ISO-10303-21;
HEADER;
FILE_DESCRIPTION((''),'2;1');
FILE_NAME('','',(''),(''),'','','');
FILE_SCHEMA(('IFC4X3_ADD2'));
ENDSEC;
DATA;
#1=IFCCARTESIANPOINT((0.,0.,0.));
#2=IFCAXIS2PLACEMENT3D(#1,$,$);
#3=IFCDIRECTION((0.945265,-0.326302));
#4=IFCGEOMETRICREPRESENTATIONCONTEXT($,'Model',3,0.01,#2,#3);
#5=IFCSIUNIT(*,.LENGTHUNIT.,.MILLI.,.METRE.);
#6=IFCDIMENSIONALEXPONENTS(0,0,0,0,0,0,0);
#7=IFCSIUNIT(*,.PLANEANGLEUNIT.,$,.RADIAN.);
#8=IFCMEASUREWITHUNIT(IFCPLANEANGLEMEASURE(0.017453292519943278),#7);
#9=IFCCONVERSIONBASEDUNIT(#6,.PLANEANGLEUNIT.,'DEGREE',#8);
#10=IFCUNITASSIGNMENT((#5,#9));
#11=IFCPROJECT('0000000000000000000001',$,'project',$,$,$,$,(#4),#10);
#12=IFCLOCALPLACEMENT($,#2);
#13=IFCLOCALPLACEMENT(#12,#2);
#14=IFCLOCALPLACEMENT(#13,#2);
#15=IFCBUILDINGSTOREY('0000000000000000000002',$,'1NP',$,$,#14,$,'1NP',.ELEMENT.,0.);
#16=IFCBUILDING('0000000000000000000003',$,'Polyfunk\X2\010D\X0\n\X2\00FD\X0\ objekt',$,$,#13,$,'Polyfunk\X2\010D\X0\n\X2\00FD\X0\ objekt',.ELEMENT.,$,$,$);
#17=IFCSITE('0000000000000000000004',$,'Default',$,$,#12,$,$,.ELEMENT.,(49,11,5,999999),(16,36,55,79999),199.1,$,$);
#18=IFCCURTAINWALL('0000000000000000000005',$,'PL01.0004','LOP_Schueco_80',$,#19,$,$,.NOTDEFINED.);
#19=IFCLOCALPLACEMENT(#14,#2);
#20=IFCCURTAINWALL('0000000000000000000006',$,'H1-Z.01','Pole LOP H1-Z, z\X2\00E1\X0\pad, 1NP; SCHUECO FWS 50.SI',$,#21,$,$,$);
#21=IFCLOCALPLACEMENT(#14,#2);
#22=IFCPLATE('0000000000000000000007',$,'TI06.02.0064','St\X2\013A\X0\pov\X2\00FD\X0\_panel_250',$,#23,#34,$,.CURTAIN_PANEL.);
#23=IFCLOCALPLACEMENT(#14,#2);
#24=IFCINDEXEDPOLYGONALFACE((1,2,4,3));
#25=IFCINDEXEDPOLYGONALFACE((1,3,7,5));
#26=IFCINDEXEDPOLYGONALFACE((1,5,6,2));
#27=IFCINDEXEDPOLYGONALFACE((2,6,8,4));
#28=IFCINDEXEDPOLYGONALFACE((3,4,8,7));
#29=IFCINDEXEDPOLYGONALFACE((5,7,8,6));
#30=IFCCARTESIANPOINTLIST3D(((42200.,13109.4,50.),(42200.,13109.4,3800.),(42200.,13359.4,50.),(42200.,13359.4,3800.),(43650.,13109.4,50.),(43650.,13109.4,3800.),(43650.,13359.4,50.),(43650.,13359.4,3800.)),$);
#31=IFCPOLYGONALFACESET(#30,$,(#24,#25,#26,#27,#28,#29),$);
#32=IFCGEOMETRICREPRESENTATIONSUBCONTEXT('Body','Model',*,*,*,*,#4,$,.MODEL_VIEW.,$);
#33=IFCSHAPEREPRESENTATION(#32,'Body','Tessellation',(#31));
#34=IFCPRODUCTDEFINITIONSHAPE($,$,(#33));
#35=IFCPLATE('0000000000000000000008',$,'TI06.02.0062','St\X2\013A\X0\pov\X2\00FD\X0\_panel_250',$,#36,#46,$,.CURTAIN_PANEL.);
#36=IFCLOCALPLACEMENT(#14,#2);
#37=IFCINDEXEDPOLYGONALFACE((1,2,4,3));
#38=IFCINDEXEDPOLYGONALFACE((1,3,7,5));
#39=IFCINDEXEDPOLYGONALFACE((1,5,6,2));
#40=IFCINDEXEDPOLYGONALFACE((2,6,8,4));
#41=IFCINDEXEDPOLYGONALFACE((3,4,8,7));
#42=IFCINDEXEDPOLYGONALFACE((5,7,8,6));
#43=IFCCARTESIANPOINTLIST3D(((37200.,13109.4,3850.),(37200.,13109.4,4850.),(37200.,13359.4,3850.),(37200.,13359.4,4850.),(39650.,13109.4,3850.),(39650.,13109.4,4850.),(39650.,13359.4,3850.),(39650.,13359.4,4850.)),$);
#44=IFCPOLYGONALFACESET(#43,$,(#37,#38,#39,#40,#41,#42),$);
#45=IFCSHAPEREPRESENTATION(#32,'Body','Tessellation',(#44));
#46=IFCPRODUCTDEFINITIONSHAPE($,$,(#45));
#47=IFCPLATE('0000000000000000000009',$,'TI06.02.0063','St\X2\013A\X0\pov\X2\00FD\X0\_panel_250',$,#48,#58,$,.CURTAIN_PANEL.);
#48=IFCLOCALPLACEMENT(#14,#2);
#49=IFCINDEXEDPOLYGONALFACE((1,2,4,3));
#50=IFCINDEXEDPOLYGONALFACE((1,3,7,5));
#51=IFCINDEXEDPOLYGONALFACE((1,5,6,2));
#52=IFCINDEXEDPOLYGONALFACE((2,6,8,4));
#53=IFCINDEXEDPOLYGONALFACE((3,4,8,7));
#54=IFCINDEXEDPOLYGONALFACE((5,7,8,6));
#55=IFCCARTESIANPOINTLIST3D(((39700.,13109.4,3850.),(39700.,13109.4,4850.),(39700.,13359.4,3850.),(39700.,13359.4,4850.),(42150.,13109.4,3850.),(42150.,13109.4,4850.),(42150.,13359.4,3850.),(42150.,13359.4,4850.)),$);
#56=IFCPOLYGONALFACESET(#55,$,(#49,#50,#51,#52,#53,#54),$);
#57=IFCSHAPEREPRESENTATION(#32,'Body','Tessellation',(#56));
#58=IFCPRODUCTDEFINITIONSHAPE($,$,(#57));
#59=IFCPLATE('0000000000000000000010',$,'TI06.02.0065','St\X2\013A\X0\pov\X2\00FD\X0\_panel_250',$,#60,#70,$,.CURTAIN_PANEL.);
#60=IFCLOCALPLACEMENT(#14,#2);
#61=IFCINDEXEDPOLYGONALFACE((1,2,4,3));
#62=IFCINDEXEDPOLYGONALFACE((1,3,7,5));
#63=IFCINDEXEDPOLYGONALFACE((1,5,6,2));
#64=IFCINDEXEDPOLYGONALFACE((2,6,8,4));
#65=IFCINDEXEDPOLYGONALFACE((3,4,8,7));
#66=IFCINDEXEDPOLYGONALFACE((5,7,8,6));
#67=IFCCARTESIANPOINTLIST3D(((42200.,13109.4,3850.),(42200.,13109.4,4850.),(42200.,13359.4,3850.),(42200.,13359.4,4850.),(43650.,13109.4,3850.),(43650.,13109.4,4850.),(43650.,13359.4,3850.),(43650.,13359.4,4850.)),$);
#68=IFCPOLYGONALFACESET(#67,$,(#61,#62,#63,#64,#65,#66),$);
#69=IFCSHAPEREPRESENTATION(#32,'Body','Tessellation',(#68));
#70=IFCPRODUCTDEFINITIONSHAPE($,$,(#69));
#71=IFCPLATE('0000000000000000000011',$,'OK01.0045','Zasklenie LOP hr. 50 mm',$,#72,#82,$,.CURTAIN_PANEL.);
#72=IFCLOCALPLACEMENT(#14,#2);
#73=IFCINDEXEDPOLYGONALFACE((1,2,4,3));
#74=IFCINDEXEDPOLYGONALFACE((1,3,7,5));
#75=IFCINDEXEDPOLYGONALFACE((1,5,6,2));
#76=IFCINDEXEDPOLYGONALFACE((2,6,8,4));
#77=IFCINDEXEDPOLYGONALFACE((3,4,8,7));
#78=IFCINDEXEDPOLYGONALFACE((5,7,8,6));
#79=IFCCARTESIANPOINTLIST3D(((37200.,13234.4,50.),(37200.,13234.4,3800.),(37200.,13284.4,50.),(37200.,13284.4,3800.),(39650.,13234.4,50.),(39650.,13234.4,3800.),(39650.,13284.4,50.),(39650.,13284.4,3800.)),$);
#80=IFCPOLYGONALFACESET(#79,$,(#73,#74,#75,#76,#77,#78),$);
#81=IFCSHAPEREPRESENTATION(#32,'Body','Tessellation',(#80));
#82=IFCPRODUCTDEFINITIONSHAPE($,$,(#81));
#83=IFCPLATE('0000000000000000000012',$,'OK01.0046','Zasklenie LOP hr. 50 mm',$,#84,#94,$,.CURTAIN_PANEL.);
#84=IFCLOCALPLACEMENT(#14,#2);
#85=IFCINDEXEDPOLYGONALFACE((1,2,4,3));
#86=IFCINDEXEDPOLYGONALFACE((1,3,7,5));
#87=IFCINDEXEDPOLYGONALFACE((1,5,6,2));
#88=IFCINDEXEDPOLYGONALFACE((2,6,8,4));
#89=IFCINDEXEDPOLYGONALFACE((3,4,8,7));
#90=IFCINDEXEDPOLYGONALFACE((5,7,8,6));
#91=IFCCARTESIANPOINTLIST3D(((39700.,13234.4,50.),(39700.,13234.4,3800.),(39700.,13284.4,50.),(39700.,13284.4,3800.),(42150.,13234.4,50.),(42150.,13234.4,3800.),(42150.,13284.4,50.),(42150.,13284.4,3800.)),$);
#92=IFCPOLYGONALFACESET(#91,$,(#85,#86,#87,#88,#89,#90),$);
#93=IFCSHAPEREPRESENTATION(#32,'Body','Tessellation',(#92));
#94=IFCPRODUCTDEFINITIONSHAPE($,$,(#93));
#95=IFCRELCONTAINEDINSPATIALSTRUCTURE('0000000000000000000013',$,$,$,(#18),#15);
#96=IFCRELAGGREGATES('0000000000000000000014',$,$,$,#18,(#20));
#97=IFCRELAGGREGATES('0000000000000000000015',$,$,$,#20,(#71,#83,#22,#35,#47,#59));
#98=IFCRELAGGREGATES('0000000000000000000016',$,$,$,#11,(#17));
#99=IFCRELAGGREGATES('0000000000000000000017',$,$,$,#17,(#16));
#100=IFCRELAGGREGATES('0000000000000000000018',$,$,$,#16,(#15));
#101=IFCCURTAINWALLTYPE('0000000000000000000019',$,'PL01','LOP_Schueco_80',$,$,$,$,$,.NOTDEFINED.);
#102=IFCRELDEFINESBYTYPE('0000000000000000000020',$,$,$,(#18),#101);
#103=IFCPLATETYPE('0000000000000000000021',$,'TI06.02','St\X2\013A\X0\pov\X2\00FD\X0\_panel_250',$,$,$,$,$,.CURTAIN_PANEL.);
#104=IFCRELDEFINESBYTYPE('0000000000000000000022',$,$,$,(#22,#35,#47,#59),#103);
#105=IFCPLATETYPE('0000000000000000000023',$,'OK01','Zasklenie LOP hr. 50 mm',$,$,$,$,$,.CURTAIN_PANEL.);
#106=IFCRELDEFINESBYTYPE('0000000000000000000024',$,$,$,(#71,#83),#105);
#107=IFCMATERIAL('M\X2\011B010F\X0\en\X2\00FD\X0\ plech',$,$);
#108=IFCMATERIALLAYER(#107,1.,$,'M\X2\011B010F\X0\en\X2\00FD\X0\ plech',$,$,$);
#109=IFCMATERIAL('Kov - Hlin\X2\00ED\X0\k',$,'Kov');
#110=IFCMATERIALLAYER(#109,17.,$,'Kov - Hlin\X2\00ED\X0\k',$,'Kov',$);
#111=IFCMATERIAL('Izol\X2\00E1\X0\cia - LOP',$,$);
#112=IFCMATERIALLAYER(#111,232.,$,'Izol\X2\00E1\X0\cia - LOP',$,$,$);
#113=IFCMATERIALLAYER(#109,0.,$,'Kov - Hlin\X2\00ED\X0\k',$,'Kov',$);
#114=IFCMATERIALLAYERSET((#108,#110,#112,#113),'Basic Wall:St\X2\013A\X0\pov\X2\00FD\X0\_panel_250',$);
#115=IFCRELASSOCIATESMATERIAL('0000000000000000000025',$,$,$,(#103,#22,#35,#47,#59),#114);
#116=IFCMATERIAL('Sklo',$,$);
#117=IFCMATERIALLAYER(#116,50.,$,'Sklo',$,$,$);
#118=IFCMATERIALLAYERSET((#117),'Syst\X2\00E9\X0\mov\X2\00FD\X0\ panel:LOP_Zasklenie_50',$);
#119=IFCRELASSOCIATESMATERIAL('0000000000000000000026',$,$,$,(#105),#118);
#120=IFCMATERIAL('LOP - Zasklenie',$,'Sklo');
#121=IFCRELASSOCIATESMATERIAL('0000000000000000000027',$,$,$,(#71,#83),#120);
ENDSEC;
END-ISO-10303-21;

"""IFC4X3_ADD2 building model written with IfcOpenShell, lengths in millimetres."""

from ifc_helpers import new_model, entity, si_unit, converted_unit, direction, frame, frame_2d, origin, origin_2d_with_axis, place, context, subcontext, project, spatial, rectangle, extrude, source, transform, mapped, material, layer, layer_set, layer_usage, type_object, type_shapes, element, aggregate, save


model = new_model("IFC4X3_ADD2")

# Units and contexts
model_context = context("Model", 3, precision=0.01, world=origin(), true_north=direction((0.945265, -0.326302)))
body_context = subcontext(model_context, "Body", "Model", "MODEL_VIEW")
ifc_project = project(units=[si_unit("LENGTHUNIT", "METRE", prefix="MILLI"), converted_unit("PLANEANGLEUNIT", "DEGREE", entity("IfcPlaneAngleMeasure", 0.017453292519943278), si_unit("PLANEANGLEUNIT", "RADIAN"), dimensions=[0, 0, 0, 0, 0, 0, 0])], contexts=[model_context])

# Site, building, storey
site_placement = place(None, origin())
site = spatial("IfcSite", under=ifc_project, at=site_placement, Name="Default", CompositionType="ELEMENT", RefLatitude=(49, 11, 5, 999999), RefLongitude=(16, 36, 55, 79999), RefElevation=199.1)
building_placement = place(site_placement, origin())
building = spatial("IfcBuilding", under=site, at=building_placement, Name="Polyfunkčný objekt", LongName="Polyfunkčný objekt", CompositionType="ELEMENT")
storey_placement = place(building_placement, origin())
storey = spatial("IfcBuildingStorey", under=building, at=storey_placement, Name="1NP", LongName="1NP", CompositionType="ELEMENT", Elevation=0.0)

# Curtain walls, plates
curtain_wall_type = type_object("IfcCurtainWallType", Name="PL01", Description="LOP_Schueco_80", PredefinedType="NOTDEFINED")
curtain_wall_1_placement = place(storey_placement, origin())
curtain_wall_1 = element("IfcCurtainWall", 1, at=curtain_wall_1_placement, inside=storey, type_object=curtain_wall_type, Name="PL01.0004", Description="LOP_Schueco_80", PredefinedType="NOTDEFINED")
curtain_wall_2 = element("IfcCurtainWall", 2, Name="H1-Z.01", Description="Pole LOP H1-Z, západ, 1NP; SCHUECO FWS 50.SI")
aggregate(curtain_wall_1, [curtain_wall_2])
ifc_material_1 = material(Name="Měďený plech")
ifc_layer_1 = layer(ifc_material_1, 1.0, Name="Měďený plech")
ifc_material_2 = material(Name="Kov - Hliník", Category="Kov")
ifc_layer_2 = layer(ifc_material_2, 17.0, Name="Kov - Hliník", Category="Kov")
ifc_material_3 = material(Name="Izolácia - LOP")
ifc_layer_3 = layer(ifc_material_3, 232.0, Name="Izolácia - LOP")
ifc_layer_4 = layer(ifc_material_2, 0.0, Name="Kov - Hliník", Category="Kov")
ifc_layer_set_1 = layer_set([ifc_layer_1, ifc_layer_2, ifc_layer_3, ifc_layer_4], Name="Basic Wall:Stĺpový_panel_250")
ifc_layer_usage_1 = layer_usage(ifc_layer_set_1, "AXIS2", "NEGATIVE", 125.0)
plate_type_1 = type_object("IfcPlateType", Name="TI06.02", Description="Stĺpový_panel_250", PredefinedType="CURTAIN_PANEL", material=ifc_layer_set_1)
plate_1_placement = place(storey_placement, frame((42200.0, 13234.4, 50.0)))
plate_1 = element("IfcPlate", 3, at=plate_1_placement, type_object=plate_type_1, material=ifc_layer_usage_1, Name="TI06.02.0064", Description="Stĺpový_panel_250", PredefinedType="CURTAIN_PANEL", context=body_context, shape_type="SweptSolid", body=[
    extrude(rectangle(XDim=250.0, YDim=1450.0, at=frame_2d((0.0, 0.0), x_axis=(1.0, 0.0))), frame((725.0, 0.0, 0.0), z_axis=(0.0, 0.0, 1.0), x_axis=(0.0, 1.0, 0.0)), (0.0, 0.0, 1.0), 3750.0),
])
ifc_layer_usage_2 = layer_usage(ifc_layer_set_1, "AXIS2", "NEGATIVE", 125.0)
plate_2_placement = place(storey_placement, frame((37200.0, 13234.4, 3850.0)))
plate_2 = element("IfcPlate", 4, at=plate_2_placement, type_object=plate_type_1, material=ifc_layer_usage_2, Name="TI06.02.0062", Description="Stĺpový_panel_250", PredefinedType="CURTAIN_PANEL", context=body_context, shape_type="SweptSolid", body=[
    extrude(rectangle(XDim=250.0, YDim=2450.0, at=frame_2d((0.0, 0.0), x_axis=(1.0, 0.0))), frame((1225.0, 0.0, 0.0), z_axis=(0.0, 0.0, 1.0), x_axis=(0.0, 1.0, 0.0)), (0.0, 0.0, 1.0), 1000.0),
])
ifc_layer_usage_3 = layer_usage(ifc_layer_set_1, "AXIS2", "NEGATIVE", 125.0)
plate_3_placement = place(storey_placement, frame((39700.0, 13234.4, 3850.0)))
plate_3 = element("IfcPlate", 5, at=plate_3_placement, type_object=plate_type_1, material=ifc_layer_usage_3, Name="TI06.02.0063", Description="Stĺpový_panel_250", PredefinedType="CURTAIN_PANEL", context=body_context, shape_type="SweptSolid", body=[
    extrude(rectangle(XDim=250.0, YDim=2450.0, at=frame_2d((0.0, 0.0), x_axis=(1.0, 0.0))), frame((1225.0, 0.0, 0.0), z_axis=(0.0, 0.0, 1.0), x_axis=(0.0, 1.0, 0.0)), (0.0, 0.0, 1.0), 1000.0),
])
ifc_layer_usage_4 = layer_usage(ifc_layer_set_1, "AXIS2", "NEGATIVE", 125.0)
plate_4_placement = place(storey_placement, frame((42200.0, 13234.4, 3850.0)))
plate_4 = element("IfcPlate", 6, at=plate_4_placement, type_object=plate_type_1, material=ifc_layer_usage_4, Name="TI06.02.0065", Description="Stĺpový_panel_250", PredefinedType="CURTAIN_PANEL", context=body_context, shape_type="SweptSolid", body=[
    extrude(rectangle(XDim=250.0, YDim=1450.0, at=origin_2d_with_axis()), frame((725.0, 0.0, 0.0), z_axis=(0.0, 0.0, 1.0), x_axis=(0.0, 1.0, 0.0)), (0.0, 0.0, 1.0), 1000.0),
])
ifc_material_4 = material(Name="LOP - Zasklenie", Category="Sklo")
ifc_material_5 = material(Name="Sklo")
ifc_layer_5 = layer(ifc_material_5, 50.0, Name="Sklo")
ifc_layer_set_2 = layer_set([ifc_layer_5], Name="Systémový panel:LOP_Zasklenie_50")
plate_type_2 = type_object("IfcPlateType", Name="OK01", Description="Zasklenie LOP hr. 50 mm", PredefinedType="CURTAIN_PANEL", material=ifc_layer_set_2)
shared_shape_1 = source(origin(), body_context, "Body", "SweptSolid", [
    extrude(rectangle(XDim=3750.0, YDim=2450.0, at=frame_2d((-141.7, 0.0), x_axis=(1.0, 0.0))), frame((0.0, 0.0, 2016.7), z_axis=(0.0, 1.0, 0.0), x_axis=(0.0, 0.0, 1.0)), (0.0, 0.0, 1.0), 50.0),
])
type_shapes(plate_type_2, [shared_shape_1])
plate_5_placement = place(curtain_wall_1_placement, frame((38425.0, 13234.4, 50.0)))
plate_5 = element("IfcPlate", 7, at=plate_5_placement, type_object=plate_type_2, material=ifc_material_4, Name="OK01.0045", Description="Zasklenie LOP hr. 50 mm", PredefinedType="CURTAIN_PANEL", context=body_context, shape_type="MappedRepresentation", body=[
    mapped(shared_shape_1, transform((0.0, 0.0, 0.0), scale=1.0)),
])
plate_6_placement = place(curtain_wall_1_placement, frame((40925.0, 13234.4, 50.0)))
plate_6 = element("IfcPlate", 8, at=plate_6_placement, type_object=plate_type_2, material=ifc_material_4, Name="OK01.0046", Description="Zasklenie LOP hr. 50 mm", PredefinedType="CURTAIN_PANEL", context=body_context, shape_type="MappedRepresentation", body=[
    mapped(shared_shape_1, transform((0.0, 0.0, 0.0), scale=1.0)),
])
aggregate(curtain_wall_2, [plate_5, plate_6, plate_1, plate_2, plate_3, plate_4])

save(model, "model.ifc")
